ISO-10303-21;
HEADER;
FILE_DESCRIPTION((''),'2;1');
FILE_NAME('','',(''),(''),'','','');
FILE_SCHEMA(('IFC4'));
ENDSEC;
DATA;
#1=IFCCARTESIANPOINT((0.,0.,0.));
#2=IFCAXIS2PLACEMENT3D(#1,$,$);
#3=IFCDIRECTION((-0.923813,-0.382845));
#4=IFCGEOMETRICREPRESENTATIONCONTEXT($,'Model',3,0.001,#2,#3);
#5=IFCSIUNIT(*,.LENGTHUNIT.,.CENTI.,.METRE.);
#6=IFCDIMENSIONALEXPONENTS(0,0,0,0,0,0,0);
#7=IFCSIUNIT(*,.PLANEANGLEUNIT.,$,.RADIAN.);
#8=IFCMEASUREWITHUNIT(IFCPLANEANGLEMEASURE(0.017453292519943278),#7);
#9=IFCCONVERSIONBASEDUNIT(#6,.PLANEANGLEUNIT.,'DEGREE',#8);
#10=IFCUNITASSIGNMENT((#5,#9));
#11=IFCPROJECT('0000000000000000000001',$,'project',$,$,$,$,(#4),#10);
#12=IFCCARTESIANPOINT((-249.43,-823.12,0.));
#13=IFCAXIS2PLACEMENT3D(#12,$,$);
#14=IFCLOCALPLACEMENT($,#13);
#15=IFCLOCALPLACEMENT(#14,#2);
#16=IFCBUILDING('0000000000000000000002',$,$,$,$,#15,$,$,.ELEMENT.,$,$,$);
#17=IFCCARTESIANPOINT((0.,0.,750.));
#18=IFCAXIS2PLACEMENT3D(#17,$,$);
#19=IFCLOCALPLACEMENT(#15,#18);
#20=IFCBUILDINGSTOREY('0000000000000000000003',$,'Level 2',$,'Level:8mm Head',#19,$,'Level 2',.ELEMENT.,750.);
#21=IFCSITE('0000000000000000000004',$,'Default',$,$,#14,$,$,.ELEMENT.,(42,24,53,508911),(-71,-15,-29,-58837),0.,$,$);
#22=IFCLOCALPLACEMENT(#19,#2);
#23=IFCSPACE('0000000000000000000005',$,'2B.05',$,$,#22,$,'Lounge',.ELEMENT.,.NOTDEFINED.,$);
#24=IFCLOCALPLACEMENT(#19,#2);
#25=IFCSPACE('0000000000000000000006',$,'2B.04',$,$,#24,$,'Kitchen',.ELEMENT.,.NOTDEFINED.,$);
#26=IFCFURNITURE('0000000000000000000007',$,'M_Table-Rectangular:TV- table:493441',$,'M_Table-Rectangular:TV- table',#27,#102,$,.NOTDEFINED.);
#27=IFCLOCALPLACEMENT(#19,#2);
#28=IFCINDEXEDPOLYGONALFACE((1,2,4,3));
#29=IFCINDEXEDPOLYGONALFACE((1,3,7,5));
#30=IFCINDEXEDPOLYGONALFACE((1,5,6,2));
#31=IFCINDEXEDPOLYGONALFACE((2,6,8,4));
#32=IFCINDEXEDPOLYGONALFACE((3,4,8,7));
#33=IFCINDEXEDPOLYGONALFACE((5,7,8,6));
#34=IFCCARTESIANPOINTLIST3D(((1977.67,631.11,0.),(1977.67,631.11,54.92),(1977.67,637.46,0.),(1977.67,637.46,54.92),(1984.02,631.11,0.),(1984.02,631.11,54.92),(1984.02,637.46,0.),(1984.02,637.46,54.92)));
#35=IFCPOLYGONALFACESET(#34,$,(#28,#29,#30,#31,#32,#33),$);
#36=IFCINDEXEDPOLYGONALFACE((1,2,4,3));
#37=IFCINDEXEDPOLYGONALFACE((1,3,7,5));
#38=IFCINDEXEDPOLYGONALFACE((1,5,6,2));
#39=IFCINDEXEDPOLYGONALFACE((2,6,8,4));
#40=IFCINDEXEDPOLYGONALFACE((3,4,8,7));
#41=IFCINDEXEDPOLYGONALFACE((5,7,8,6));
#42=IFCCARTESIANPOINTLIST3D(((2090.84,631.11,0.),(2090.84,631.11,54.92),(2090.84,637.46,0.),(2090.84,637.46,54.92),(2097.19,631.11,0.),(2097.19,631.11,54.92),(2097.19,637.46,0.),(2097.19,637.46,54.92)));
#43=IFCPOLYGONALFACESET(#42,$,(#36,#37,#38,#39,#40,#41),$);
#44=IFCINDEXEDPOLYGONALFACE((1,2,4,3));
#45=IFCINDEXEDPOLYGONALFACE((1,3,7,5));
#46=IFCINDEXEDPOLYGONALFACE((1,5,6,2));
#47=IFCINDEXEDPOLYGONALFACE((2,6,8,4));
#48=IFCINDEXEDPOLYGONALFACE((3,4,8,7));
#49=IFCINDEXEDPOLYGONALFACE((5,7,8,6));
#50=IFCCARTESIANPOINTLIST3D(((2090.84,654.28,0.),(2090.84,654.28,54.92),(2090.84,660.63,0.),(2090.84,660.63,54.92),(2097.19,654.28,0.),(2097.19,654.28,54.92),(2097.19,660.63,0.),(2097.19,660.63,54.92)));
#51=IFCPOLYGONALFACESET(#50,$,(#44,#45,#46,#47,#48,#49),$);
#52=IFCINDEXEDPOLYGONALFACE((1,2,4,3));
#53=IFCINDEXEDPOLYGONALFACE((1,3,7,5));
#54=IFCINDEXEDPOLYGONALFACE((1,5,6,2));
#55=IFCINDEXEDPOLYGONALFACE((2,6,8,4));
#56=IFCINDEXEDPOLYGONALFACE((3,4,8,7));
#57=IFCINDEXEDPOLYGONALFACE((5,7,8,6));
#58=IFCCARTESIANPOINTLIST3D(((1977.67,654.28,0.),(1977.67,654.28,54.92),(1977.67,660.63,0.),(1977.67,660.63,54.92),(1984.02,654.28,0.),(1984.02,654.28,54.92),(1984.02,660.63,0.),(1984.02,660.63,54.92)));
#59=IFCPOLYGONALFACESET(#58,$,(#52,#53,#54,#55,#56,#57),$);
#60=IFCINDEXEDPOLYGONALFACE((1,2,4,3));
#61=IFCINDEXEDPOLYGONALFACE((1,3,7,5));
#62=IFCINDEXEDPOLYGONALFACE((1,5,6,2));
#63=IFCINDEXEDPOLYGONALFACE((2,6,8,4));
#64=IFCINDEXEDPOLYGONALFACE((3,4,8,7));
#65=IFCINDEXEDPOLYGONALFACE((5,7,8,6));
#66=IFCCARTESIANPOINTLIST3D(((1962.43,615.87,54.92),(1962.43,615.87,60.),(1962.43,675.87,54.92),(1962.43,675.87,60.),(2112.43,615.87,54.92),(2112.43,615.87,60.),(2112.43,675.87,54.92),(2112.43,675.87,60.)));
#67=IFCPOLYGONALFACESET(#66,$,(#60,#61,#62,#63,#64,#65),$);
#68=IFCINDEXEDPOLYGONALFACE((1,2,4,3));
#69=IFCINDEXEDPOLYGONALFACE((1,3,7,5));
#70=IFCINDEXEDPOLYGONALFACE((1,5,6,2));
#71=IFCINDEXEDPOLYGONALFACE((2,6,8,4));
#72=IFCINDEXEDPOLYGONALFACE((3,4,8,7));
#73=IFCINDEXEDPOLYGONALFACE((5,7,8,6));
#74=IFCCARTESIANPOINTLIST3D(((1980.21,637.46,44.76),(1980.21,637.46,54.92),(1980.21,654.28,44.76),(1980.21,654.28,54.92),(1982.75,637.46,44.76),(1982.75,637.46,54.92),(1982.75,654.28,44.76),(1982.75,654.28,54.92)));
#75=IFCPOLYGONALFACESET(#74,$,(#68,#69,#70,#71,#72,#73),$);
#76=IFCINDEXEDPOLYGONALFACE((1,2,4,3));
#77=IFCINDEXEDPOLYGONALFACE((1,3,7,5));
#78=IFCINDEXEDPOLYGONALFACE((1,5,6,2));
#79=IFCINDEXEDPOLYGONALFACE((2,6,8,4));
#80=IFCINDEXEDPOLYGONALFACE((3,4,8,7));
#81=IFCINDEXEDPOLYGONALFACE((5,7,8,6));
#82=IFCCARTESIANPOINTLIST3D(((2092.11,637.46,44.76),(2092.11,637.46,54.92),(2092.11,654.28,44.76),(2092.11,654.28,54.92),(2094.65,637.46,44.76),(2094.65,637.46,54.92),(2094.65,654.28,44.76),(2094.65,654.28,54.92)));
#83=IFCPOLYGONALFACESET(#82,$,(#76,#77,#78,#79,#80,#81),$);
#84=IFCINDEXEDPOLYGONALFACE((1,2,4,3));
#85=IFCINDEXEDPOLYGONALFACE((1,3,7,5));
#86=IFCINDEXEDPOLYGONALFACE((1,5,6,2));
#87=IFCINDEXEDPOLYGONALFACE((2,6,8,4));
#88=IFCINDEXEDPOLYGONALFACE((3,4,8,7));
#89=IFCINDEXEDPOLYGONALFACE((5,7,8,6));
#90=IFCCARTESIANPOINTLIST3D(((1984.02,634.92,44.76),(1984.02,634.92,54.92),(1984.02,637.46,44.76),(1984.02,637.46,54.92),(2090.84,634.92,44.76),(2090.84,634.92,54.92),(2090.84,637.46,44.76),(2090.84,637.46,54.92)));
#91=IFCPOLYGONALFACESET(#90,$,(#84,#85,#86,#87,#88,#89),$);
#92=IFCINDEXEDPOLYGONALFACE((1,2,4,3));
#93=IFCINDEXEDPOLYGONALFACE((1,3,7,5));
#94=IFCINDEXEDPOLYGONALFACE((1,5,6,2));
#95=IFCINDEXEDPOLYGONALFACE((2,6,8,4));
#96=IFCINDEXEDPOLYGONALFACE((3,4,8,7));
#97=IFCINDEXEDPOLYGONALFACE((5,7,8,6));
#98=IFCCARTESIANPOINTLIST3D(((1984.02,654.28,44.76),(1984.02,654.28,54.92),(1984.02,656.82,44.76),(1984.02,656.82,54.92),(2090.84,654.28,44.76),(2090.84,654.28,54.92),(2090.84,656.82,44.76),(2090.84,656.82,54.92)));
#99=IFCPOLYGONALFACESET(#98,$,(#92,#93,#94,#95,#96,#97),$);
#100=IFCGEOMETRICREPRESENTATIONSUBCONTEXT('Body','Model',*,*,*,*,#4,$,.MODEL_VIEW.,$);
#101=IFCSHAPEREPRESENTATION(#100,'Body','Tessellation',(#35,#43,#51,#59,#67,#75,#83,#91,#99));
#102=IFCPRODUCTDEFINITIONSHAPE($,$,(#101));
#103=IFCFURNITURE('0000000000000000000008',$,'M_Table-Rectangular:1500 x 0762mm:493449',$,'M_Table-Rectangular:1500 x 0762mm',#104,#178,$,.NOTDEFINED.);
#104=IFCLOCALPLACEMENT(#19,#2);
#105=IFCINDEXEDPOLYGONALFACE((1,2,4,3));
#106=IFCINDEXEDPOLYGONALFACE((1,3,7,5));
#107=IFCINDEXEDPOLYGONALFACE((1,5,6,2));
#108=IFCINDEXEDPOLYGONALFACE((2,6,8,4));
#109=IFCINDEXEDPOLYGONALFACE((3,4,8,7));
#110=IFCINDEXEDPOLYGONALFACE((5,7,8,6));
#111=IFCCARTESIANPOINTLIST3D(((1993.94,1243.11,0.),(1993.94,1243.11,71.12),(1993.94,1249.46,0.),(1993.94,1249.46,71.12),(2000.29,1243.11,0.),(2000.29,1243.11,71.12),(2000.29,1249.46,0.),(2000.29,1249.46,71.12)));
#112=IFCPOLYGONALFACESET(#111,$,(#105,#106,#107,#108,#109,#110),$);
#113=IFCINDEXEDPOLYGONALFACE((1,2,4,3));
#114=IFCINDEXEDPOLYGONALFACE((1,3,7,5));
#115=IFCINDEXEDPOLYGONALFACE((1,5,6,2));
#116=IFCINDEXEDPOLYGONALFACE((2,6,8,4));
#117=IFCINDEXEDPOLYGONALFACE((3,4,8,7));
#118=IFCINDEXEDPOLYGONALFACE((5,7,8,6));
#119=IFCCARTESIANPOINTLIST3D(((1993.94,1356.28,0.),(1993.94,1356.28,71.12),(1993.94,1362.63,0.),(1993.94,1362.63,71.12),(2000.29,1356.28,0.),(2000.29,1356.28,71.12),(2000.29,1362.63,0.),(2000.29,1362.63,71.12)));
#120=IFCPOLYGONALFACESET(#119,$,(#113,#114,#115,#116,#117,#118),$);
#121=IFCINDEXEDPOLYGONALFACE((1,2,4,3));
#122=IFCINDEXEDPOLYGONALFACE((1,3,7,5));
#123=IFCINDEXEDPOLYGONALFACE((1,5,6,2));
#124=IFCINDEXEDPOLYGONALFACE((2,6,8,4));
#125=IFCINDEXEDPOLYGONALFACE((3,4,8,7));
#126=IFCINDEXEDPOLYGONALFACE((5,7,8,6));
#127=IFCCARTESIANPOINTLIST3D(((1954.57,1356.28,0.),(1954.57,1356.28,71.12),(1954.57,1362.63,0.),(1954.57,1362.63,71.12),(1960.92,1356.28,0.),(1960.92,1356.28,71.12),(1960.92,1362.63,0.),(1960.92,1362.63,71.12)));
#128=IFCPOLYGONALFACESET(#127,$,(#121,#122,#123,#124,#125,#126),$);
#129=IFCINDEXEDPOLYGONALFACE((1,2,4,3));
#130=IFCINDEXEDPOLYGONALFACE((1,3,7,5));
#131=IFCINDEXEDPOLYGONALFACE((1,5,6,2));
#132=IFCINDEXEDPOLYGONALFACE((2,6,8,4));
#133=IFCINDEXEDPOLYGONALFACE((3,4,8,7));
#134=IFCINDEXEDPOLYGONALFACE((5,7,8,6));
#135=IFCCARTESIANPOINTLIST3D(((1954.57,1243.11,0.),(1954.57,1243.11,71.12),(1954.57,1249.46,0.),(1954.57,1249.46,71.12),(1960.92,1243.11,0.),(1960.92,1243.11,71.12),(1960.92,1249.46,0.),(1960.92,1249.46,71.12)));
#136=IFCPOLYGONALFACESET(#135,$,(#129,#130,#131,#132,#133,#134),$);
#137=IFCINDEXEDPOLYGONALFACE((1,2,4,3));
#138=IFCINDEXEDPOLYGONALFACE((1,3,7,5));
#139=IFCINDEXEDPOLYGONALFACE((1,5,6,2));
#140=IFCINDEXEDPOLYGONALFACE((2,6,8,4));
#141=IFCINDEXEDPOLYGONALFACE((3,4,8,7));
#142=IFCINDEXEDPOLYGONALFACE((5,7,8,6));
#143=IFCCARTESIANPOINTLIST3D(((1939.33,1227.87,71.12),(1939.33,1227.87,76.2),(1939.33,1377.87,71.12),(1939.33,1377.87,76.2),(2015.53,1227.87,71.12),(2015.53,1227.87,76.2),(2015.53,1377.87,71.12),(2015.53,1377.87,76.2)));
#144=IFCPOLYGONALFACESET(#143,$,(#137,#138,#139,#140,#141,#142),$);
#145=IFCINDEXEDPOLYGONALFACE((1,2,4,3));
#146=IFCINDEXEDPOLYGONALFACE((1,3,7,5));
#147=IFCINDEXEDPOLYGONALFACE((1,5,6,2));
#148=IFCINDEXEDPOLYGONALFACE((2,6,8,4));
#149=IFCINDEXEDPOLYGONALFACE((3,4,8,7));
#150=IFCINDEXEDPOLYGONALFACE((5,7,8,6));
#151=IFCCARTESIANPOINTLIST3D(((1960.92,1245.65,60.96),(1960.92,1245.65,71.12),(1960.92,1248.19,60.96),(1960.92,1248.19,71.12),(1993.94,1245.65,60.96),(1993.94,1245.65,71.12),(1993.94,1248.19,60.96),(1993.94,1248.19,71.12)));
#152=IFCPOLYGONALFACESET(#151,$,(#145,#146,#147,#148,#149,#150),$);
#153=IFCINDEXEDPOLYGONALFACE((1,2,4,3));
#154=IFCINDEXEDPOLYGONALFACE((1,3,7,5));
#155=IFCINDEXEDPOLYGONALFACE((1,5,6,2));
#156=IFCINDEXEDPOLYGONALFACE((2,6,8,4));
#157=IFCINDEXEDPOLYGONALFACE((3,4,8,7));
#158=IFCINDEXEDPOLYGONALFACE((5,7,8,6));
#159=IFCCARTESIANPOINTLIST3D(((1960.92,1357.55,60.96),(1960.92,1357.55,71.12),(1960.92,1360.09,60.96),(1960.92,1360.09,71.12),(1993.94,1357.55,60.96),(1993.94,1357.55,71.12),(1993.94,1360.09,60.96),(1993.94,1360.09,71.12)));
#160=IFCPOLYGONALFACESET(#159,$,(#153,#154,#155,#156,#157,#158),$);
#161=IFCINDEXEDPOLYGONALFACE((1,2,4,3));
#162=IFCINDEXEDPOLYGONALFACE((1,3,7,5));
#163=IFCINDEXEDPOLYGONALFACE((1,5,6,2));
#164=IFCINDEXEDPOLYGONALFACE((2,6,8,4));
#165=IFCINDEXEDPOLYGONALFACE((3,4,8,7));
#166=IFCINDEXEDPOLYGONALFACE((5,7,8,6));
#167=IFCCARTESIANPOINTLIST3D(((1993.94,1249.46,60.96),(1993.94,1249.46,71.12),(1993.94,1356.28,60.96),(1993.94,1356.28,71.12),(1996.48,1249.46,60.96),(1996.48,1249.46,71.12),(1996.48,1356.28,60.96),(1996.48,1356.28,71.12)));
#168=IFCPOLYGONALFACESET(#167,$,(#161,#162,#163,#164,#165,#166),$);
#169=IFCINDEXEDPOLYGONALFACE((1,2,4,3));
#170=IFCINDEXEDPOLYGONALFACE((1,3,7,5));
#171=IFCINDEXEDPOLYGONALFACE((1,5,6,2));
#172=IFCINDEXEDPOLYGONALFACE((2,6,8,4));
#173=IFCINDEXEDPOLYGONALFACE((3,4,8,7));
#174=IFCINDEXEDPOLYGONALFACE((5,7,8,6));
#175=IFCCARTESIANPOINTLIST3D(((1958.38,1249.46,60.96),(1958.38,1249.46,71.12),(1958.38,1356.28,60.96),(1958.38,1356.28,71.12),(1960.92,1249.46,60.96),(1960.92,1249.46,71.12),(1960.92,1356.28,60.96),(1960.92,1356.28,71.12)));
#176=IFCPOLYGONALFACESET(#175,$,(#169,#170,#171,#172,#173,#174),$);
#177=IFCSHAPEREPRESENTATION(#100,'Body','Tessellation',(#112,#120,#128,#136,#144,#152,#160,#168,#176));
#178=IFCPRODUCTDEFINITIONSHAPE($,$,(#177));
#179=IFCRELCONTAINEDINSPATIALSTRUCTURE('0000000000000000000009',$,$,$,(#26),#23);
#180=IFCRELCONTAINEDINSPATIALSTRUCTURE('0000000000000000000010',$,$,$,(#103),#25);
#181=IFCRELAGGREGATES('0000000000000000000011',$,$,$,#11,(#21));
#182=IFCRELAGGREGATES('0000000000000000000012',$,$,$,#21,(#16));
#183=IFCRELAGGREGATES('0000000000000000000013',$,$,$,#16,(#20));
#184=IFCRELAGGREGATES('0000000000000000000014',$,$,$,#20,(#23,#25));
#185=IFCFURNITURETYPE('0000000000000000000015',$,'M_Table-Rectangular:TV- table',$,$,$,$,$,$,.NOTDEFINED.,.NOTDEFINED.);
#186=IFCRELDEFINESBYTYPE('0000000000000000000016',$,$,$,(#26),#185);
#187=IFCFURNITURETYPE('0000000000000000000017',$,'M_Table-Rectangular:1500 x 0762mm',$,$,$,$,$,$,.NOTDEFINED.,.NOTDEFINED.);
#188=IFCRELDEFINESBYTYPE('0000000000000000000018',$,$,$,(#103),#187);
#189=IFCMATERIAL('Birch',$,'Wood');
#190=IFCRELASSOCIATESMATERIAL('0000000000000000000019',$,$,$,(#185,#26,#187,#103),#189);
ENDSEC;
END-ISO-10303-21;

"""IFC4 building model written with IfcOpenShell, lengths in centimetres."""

from ifc_helpers import new_model, entity, si_unit, converted_unit, direction, frame, origin, place, context, subcontext, project, spatial, indexed_curve, outline, extrude, source, transform, mapped, material, type_object, type_shapes, element, save


model = new_model("IFC4")

# Units and contexts
model_context = context("Model", 3, precision=0.001, world=origin(), true_north=direction((-0.923813, -0.382845)))
body_context = subcontext(model_context, "Body", "Model", "MODEL_VIEW")
ifc_project = project(units=[si_unit("LENGTHUNIT", "METRE", prefix="CENTI"), converted_unit("PLANEANGLEUNIT", "DEGREE", entity("IfcPlaneAngleMeasure", 0.017453292519943278), si_unit("PLANEANGLEUNIT", "RADIAN"), dimensions=[0, 0, 0, 0, 0, 0, 0])], contexts=[model_context])

# Site, building, storey
site_placement = place(None, frame((-249.43, -823.12, 0.0)))
site = spatial("IfcSite", under=ifc_project, at=site_placement, Name="Default", CompositionType="ELEMENT", RefLatitude=(42, 24, 53, 508911), RefLongitude=(-71, -15, -29, -58837), RefElevation=0.0)
building_placement = place(site_placement, origin())
building = spatial("IfcBuilding", under=site, at=building_placement, CompositionType="ELEMENT")
storey_placement = place(building_placement, frame((0.0, 0.0, 750.0)))
storey = spatial("IfcBuildingStorey", under=building, at=storey_placement, Name="Level 2", ObjectType="Level:8mm Head", LongName="Level 2", CompositionType="ELEMENT", Elevation=750.0)

# Shared definitions
space_1_placement = place(storey_placement, origin())
space_1 = spatial("IfcSpace", under=storey, at=space_1_placement, Name="2B.05", LongName="Lounge", CompositionType="ELEMENT", PredefinedType="NOTDEFINED")

# Furniture
ifc_material_1 = material(Name="Birch", Category="Wood")
furniture_type_1 = type_object("IfcFurnitureType", Name="M_Table-Rectangular:TV- table", AssemblyPlace="NOTDEFINED", PredefinedType="NOTDEFINED", material=ifc_material_1)
shared_shape_1 = source(origin(), body_context, "Body", "SweptSolid", [
    extrude(outline(indexed_curve([(-3.18, -3.18), (3.18, -3.18), (3.18, 3.18), (-3.18, 3.18), (-3.18, -3.18)], self_intersect=False)), frame((56.58, 11.59, 0.0), z_axis=(0.0, 0.0, 1.0), x_axis=(0.0, -1.0, 0.0)), (0.0, 0.0, 1.0), 54.92),
    extrude(outline(indexed_curve([(-3.17, -3.18), (3.17, -3.18), (3.17, 3.18), (-3.17, 3.18), (-3.17, -3.18)], self_intersect=False)), frame((-56.58, 11.59, 0.0), z_axis=(0.0, 0.0, 1.0), x_axis=(-1.0, 0.0, 0.0)), (0.0, 0.0, 1.0), 54.92),
    extrude(outline(indexed_curve([(-3.17, -3.17), (3.17, -3.17), (3.17, 3.17), (-3.17, 3.17), (-3.17, -3.17)], self_intersect=False)), frame((-56.58, -11.59, 0.0), z_axis=(0.0, 0.0, 1.0), x_axis=(0.0, 1.0, 0.0)), (0.0, 0.0, 1.0), 54.92),
    extrude(outline(indexed_curve([(-3.18, -3.17), (3.18, -3.17), (3.18, 3.17), (-3.18, 3.17), (-3.18, -3.17)], self_intersect=False)), frame((56.58, -11.59, 0.0)), (0.0, 0.0, 1.0), 54.92),
    extrude(outline(indexed_curve([(-75.0, -30.0), (75.0, -30.0), (75.0, 30.0), (-75.0, 30.0), (-75.0, -30.0)], self_intersect=False)), frame((0.0, 0.0, 54.92), z_axis=(0.0, 0.0, 1.0), x_axis=(-1.0, 0.0, 0.0)), (0.0, 0.0, 1.0), 5.08),
    extrude(outline(indexed_curve([(-1.27, -8.41), (1.27, -8.41), (1.27, 8.41), (-1.27, 8.41), (-1.27, -8.41)], self_intersect=False)), frame((55.95, 0.0, 44.76)), (0.0, 0.0, 1.0), 10.16),
    extrude(outline(indexed_curve([(-8.41, -1.27), (8.41, -1.27), (8.41, 1.27), (-8.41, 1.27), (-8.41, -1.27)], self_intersect=False)), frame((-55.95, 0.0, 44.76), z_axis=(0.0, 0.0, 1.0), x_axis=(0.0, 1.0, 0.0)), (0.0, 0.0, 1.0), 10.16),
    extrude(outline(indexed_curve([(-53.41, -1.27), (53.41, -1.27), (53.41, 1.27), (-53.41, 1.27), (-53.41, -1.27)], self_intersect=False)), frame((0.0, 9.68, 44.76), z_axis=(0.0, 0.0, 1.0), x_axis=(-1.0, 0.0, 0.0)), (0.0, 0.0, 1.0), 10.16),
    extrude(outline(indexed_curve([(-1.27, -53.41), (1.27, -53.41), (1.27, 53.41), (-1.27, 53.41), (-1.27, -53.41)], self_intersect=False)), frame((0.0, -9.68, 44.76), z_axis=(0.0, 0.0, 1.0), x_axis=(0.0, 1.0, 0.0)), (0.0, 0.0, 1.0), 10.16),
])
type_shapes(furniture_type_1, [shared_shape_1])
furniture_1_placement = place(space_1_placement, frame((2037.43, 645.87, 0.0), z_axis=(0.0, 0.0, 1.0), x_axis=(-1.0, 0.0, 0.0)))
element("IfcFurniture", 1, at=furniture_1_placement, inside=space_1, type_object=furniture_type_1, material=ifc_material_1, Name="M_Table-Rectangular:TV- table:493441", ObjectType="M_Table-Rectangular:TV- table", PredefinedType="NOTDEFINED", context=body_context, shape_type="MappedRepresentation", body=[
    mapped(shared_shape_1, transform((0.0, 0.0, 0.0), scale=1.0)),
])

# Shared definitions
space_2_placement = place(storey_placement, origin())
space_2 = spatial("IfcSpace", under=storey, at=space_2_placement, Name="2B.04", LongName="Kitchen", CompositionType="ELEMENT", PredefinedType="NOTDEFINED")

# Furniture
furniture_type_2 = type_object("IfcFurnitureType", Name="M_Table-Rectangular:1500 x 0762mm", AssemblyPlace="NOTDEFINED", PredefinedType="NOTDEFINED", material=ifc_material_1)
shared_shape_2 = source(origin(), body_context, "Body", "SweptSolid", [
    extrude(outline(indexed_curve([(-3.18, -3.18), (3.18, -3.18), (3.18, 3.18), (-3.18, 3.18), (-3.18, -3.18)], self_intersect=False)), frame((56.58, 19.69, 0.0), z_axis=(0.0, 0.0, 1.0), x_axis=(0.0, -1.0, 0.0)), (0.0, 0.0, 1.0), 71.12),
    extrude(outline(indexed_curve([(-3.17, -3.18), (3.17, -3.18), (3.17, 3.18), (-3.17, 3.18), (-3.17, -3.18)], self_intersect=False)), frame((-56.58, 19.69, 0.0), z_axis=(0.0, 0.0, 1.0), x_axis=(-1.0, 0.0, 0.0)), (0.0, 0.0, 1.0), 71.12),
    extrude(outline(indexed_curve([(-3.17, -3.17), (3.17, -3.17), (3.17, 3.17), (-3.17, 3.17), (-3.17, -3.17)], self_intersect=False)), frame((-56.58, -19.69, 0.0), z_axis=(0.0, 0.0, 1.0), x_axis=(0.0, 1.0, 0.0)), (0.0, 0.0, 1.0), 71.12),
    extrude(outline(indexed_curve([(-3.18, -3.17), (3.18, -3.17), (3.18, 3.18), (-3.18, 3.18), (-3.18, -3.17)], self_intersect=False)), frame((56.58, -19.69, 0.0)), (0.0, 0.0, 1.0), 71.12),
    extrude(outline(indexed_curve([(-75.0, -38.1), (75.0, -38.1), (75.0, 38.1), (-75.0, 38.1), (-75.0, -38.1)], self_intersect=False)), frame((0.0, 0.0, 71.12), z_axis=(0.0, 0.0, 1.0), x_axis=(-1.0, 0.0, 0.0)), (0.0, 0.0, 1.0), 5.08),
    extrude(outline(indexed_curve([(-1.27, -16.51), (1.27, -16.51), (1.27, 16.51), (-1.27, 16.51), (-1.27, -16.51)], self_intersect=False)), frame((55.95, 0.0, 60.96)), (0.0, 0.0, 1.0), 10.16),
    extrude(outline(indexed_curve([(-16.51, -1.27), (16.51, -1.27), (16.51, 1.27), (-16.51, 1.27), (-16.51, -1.27)], self_intersect=False)), frame((-55.95, 0.0, 60.96), z_axis=(0.0, 0.0, 1.0), x_axis=(0.0, 1.0, 0.0)), (0.0, 0.0, 1.0), 10.16),
    extrude(outline(indexed_curve([(-53.41, -1.27), (53.41, -1.27), (53.41, 1.27), (-53.41, 1.27), (-53.41, -1.27)], self_intersect=False)), frame((0.0, 17.78, 60.96), z_axis=(0.0, 0.0, 1.0), x_axis=(-1.0, 0.0, 0.0)), (0.0, 0.0, 1.0), 10.16),
    extrude(outline(indexed_curve([(-1.27, -53.41), (1.27, -53.41), (1.27, 53.41), (-1.27, 53.41), (-1.27, -53.41)], self_intersect=False)), frame((0.0, -17.78, 60.96), z_axis=(0.0, 0.0, 1.0), x_axis=(0.0, 1.0, 0.0)), (0.0, 0.0, 1.0), 10.16),
])
type_shapes(furniture_type_2, [shared_shape_2])
furniture_2_placement = place(space_2_placement, frame((1977.43, 1302.87, 0.0), z_axis=(0.0, 0.0, 1.0), x_axis=(0.0, -1.0, 0.0)))
element("IfcFurniture", 2, at=furniture_2_placement, inside=space_2, type_object=furniture_type_2, material=ifc_material_1, Name="M_Table-Rectangular:1500 x 0762mm:493449", ObjectType="M_Table-Rectangular:1500 x 0762mm", PredefinedType="NOTDEFINED", context=body_context, shape_type="MappedRepresentation", body=[
    mapped(shared_shape_2, transform((0.0, 0.0, 0.0), scale=1.0)),
])

save(model, "model.ifc")
